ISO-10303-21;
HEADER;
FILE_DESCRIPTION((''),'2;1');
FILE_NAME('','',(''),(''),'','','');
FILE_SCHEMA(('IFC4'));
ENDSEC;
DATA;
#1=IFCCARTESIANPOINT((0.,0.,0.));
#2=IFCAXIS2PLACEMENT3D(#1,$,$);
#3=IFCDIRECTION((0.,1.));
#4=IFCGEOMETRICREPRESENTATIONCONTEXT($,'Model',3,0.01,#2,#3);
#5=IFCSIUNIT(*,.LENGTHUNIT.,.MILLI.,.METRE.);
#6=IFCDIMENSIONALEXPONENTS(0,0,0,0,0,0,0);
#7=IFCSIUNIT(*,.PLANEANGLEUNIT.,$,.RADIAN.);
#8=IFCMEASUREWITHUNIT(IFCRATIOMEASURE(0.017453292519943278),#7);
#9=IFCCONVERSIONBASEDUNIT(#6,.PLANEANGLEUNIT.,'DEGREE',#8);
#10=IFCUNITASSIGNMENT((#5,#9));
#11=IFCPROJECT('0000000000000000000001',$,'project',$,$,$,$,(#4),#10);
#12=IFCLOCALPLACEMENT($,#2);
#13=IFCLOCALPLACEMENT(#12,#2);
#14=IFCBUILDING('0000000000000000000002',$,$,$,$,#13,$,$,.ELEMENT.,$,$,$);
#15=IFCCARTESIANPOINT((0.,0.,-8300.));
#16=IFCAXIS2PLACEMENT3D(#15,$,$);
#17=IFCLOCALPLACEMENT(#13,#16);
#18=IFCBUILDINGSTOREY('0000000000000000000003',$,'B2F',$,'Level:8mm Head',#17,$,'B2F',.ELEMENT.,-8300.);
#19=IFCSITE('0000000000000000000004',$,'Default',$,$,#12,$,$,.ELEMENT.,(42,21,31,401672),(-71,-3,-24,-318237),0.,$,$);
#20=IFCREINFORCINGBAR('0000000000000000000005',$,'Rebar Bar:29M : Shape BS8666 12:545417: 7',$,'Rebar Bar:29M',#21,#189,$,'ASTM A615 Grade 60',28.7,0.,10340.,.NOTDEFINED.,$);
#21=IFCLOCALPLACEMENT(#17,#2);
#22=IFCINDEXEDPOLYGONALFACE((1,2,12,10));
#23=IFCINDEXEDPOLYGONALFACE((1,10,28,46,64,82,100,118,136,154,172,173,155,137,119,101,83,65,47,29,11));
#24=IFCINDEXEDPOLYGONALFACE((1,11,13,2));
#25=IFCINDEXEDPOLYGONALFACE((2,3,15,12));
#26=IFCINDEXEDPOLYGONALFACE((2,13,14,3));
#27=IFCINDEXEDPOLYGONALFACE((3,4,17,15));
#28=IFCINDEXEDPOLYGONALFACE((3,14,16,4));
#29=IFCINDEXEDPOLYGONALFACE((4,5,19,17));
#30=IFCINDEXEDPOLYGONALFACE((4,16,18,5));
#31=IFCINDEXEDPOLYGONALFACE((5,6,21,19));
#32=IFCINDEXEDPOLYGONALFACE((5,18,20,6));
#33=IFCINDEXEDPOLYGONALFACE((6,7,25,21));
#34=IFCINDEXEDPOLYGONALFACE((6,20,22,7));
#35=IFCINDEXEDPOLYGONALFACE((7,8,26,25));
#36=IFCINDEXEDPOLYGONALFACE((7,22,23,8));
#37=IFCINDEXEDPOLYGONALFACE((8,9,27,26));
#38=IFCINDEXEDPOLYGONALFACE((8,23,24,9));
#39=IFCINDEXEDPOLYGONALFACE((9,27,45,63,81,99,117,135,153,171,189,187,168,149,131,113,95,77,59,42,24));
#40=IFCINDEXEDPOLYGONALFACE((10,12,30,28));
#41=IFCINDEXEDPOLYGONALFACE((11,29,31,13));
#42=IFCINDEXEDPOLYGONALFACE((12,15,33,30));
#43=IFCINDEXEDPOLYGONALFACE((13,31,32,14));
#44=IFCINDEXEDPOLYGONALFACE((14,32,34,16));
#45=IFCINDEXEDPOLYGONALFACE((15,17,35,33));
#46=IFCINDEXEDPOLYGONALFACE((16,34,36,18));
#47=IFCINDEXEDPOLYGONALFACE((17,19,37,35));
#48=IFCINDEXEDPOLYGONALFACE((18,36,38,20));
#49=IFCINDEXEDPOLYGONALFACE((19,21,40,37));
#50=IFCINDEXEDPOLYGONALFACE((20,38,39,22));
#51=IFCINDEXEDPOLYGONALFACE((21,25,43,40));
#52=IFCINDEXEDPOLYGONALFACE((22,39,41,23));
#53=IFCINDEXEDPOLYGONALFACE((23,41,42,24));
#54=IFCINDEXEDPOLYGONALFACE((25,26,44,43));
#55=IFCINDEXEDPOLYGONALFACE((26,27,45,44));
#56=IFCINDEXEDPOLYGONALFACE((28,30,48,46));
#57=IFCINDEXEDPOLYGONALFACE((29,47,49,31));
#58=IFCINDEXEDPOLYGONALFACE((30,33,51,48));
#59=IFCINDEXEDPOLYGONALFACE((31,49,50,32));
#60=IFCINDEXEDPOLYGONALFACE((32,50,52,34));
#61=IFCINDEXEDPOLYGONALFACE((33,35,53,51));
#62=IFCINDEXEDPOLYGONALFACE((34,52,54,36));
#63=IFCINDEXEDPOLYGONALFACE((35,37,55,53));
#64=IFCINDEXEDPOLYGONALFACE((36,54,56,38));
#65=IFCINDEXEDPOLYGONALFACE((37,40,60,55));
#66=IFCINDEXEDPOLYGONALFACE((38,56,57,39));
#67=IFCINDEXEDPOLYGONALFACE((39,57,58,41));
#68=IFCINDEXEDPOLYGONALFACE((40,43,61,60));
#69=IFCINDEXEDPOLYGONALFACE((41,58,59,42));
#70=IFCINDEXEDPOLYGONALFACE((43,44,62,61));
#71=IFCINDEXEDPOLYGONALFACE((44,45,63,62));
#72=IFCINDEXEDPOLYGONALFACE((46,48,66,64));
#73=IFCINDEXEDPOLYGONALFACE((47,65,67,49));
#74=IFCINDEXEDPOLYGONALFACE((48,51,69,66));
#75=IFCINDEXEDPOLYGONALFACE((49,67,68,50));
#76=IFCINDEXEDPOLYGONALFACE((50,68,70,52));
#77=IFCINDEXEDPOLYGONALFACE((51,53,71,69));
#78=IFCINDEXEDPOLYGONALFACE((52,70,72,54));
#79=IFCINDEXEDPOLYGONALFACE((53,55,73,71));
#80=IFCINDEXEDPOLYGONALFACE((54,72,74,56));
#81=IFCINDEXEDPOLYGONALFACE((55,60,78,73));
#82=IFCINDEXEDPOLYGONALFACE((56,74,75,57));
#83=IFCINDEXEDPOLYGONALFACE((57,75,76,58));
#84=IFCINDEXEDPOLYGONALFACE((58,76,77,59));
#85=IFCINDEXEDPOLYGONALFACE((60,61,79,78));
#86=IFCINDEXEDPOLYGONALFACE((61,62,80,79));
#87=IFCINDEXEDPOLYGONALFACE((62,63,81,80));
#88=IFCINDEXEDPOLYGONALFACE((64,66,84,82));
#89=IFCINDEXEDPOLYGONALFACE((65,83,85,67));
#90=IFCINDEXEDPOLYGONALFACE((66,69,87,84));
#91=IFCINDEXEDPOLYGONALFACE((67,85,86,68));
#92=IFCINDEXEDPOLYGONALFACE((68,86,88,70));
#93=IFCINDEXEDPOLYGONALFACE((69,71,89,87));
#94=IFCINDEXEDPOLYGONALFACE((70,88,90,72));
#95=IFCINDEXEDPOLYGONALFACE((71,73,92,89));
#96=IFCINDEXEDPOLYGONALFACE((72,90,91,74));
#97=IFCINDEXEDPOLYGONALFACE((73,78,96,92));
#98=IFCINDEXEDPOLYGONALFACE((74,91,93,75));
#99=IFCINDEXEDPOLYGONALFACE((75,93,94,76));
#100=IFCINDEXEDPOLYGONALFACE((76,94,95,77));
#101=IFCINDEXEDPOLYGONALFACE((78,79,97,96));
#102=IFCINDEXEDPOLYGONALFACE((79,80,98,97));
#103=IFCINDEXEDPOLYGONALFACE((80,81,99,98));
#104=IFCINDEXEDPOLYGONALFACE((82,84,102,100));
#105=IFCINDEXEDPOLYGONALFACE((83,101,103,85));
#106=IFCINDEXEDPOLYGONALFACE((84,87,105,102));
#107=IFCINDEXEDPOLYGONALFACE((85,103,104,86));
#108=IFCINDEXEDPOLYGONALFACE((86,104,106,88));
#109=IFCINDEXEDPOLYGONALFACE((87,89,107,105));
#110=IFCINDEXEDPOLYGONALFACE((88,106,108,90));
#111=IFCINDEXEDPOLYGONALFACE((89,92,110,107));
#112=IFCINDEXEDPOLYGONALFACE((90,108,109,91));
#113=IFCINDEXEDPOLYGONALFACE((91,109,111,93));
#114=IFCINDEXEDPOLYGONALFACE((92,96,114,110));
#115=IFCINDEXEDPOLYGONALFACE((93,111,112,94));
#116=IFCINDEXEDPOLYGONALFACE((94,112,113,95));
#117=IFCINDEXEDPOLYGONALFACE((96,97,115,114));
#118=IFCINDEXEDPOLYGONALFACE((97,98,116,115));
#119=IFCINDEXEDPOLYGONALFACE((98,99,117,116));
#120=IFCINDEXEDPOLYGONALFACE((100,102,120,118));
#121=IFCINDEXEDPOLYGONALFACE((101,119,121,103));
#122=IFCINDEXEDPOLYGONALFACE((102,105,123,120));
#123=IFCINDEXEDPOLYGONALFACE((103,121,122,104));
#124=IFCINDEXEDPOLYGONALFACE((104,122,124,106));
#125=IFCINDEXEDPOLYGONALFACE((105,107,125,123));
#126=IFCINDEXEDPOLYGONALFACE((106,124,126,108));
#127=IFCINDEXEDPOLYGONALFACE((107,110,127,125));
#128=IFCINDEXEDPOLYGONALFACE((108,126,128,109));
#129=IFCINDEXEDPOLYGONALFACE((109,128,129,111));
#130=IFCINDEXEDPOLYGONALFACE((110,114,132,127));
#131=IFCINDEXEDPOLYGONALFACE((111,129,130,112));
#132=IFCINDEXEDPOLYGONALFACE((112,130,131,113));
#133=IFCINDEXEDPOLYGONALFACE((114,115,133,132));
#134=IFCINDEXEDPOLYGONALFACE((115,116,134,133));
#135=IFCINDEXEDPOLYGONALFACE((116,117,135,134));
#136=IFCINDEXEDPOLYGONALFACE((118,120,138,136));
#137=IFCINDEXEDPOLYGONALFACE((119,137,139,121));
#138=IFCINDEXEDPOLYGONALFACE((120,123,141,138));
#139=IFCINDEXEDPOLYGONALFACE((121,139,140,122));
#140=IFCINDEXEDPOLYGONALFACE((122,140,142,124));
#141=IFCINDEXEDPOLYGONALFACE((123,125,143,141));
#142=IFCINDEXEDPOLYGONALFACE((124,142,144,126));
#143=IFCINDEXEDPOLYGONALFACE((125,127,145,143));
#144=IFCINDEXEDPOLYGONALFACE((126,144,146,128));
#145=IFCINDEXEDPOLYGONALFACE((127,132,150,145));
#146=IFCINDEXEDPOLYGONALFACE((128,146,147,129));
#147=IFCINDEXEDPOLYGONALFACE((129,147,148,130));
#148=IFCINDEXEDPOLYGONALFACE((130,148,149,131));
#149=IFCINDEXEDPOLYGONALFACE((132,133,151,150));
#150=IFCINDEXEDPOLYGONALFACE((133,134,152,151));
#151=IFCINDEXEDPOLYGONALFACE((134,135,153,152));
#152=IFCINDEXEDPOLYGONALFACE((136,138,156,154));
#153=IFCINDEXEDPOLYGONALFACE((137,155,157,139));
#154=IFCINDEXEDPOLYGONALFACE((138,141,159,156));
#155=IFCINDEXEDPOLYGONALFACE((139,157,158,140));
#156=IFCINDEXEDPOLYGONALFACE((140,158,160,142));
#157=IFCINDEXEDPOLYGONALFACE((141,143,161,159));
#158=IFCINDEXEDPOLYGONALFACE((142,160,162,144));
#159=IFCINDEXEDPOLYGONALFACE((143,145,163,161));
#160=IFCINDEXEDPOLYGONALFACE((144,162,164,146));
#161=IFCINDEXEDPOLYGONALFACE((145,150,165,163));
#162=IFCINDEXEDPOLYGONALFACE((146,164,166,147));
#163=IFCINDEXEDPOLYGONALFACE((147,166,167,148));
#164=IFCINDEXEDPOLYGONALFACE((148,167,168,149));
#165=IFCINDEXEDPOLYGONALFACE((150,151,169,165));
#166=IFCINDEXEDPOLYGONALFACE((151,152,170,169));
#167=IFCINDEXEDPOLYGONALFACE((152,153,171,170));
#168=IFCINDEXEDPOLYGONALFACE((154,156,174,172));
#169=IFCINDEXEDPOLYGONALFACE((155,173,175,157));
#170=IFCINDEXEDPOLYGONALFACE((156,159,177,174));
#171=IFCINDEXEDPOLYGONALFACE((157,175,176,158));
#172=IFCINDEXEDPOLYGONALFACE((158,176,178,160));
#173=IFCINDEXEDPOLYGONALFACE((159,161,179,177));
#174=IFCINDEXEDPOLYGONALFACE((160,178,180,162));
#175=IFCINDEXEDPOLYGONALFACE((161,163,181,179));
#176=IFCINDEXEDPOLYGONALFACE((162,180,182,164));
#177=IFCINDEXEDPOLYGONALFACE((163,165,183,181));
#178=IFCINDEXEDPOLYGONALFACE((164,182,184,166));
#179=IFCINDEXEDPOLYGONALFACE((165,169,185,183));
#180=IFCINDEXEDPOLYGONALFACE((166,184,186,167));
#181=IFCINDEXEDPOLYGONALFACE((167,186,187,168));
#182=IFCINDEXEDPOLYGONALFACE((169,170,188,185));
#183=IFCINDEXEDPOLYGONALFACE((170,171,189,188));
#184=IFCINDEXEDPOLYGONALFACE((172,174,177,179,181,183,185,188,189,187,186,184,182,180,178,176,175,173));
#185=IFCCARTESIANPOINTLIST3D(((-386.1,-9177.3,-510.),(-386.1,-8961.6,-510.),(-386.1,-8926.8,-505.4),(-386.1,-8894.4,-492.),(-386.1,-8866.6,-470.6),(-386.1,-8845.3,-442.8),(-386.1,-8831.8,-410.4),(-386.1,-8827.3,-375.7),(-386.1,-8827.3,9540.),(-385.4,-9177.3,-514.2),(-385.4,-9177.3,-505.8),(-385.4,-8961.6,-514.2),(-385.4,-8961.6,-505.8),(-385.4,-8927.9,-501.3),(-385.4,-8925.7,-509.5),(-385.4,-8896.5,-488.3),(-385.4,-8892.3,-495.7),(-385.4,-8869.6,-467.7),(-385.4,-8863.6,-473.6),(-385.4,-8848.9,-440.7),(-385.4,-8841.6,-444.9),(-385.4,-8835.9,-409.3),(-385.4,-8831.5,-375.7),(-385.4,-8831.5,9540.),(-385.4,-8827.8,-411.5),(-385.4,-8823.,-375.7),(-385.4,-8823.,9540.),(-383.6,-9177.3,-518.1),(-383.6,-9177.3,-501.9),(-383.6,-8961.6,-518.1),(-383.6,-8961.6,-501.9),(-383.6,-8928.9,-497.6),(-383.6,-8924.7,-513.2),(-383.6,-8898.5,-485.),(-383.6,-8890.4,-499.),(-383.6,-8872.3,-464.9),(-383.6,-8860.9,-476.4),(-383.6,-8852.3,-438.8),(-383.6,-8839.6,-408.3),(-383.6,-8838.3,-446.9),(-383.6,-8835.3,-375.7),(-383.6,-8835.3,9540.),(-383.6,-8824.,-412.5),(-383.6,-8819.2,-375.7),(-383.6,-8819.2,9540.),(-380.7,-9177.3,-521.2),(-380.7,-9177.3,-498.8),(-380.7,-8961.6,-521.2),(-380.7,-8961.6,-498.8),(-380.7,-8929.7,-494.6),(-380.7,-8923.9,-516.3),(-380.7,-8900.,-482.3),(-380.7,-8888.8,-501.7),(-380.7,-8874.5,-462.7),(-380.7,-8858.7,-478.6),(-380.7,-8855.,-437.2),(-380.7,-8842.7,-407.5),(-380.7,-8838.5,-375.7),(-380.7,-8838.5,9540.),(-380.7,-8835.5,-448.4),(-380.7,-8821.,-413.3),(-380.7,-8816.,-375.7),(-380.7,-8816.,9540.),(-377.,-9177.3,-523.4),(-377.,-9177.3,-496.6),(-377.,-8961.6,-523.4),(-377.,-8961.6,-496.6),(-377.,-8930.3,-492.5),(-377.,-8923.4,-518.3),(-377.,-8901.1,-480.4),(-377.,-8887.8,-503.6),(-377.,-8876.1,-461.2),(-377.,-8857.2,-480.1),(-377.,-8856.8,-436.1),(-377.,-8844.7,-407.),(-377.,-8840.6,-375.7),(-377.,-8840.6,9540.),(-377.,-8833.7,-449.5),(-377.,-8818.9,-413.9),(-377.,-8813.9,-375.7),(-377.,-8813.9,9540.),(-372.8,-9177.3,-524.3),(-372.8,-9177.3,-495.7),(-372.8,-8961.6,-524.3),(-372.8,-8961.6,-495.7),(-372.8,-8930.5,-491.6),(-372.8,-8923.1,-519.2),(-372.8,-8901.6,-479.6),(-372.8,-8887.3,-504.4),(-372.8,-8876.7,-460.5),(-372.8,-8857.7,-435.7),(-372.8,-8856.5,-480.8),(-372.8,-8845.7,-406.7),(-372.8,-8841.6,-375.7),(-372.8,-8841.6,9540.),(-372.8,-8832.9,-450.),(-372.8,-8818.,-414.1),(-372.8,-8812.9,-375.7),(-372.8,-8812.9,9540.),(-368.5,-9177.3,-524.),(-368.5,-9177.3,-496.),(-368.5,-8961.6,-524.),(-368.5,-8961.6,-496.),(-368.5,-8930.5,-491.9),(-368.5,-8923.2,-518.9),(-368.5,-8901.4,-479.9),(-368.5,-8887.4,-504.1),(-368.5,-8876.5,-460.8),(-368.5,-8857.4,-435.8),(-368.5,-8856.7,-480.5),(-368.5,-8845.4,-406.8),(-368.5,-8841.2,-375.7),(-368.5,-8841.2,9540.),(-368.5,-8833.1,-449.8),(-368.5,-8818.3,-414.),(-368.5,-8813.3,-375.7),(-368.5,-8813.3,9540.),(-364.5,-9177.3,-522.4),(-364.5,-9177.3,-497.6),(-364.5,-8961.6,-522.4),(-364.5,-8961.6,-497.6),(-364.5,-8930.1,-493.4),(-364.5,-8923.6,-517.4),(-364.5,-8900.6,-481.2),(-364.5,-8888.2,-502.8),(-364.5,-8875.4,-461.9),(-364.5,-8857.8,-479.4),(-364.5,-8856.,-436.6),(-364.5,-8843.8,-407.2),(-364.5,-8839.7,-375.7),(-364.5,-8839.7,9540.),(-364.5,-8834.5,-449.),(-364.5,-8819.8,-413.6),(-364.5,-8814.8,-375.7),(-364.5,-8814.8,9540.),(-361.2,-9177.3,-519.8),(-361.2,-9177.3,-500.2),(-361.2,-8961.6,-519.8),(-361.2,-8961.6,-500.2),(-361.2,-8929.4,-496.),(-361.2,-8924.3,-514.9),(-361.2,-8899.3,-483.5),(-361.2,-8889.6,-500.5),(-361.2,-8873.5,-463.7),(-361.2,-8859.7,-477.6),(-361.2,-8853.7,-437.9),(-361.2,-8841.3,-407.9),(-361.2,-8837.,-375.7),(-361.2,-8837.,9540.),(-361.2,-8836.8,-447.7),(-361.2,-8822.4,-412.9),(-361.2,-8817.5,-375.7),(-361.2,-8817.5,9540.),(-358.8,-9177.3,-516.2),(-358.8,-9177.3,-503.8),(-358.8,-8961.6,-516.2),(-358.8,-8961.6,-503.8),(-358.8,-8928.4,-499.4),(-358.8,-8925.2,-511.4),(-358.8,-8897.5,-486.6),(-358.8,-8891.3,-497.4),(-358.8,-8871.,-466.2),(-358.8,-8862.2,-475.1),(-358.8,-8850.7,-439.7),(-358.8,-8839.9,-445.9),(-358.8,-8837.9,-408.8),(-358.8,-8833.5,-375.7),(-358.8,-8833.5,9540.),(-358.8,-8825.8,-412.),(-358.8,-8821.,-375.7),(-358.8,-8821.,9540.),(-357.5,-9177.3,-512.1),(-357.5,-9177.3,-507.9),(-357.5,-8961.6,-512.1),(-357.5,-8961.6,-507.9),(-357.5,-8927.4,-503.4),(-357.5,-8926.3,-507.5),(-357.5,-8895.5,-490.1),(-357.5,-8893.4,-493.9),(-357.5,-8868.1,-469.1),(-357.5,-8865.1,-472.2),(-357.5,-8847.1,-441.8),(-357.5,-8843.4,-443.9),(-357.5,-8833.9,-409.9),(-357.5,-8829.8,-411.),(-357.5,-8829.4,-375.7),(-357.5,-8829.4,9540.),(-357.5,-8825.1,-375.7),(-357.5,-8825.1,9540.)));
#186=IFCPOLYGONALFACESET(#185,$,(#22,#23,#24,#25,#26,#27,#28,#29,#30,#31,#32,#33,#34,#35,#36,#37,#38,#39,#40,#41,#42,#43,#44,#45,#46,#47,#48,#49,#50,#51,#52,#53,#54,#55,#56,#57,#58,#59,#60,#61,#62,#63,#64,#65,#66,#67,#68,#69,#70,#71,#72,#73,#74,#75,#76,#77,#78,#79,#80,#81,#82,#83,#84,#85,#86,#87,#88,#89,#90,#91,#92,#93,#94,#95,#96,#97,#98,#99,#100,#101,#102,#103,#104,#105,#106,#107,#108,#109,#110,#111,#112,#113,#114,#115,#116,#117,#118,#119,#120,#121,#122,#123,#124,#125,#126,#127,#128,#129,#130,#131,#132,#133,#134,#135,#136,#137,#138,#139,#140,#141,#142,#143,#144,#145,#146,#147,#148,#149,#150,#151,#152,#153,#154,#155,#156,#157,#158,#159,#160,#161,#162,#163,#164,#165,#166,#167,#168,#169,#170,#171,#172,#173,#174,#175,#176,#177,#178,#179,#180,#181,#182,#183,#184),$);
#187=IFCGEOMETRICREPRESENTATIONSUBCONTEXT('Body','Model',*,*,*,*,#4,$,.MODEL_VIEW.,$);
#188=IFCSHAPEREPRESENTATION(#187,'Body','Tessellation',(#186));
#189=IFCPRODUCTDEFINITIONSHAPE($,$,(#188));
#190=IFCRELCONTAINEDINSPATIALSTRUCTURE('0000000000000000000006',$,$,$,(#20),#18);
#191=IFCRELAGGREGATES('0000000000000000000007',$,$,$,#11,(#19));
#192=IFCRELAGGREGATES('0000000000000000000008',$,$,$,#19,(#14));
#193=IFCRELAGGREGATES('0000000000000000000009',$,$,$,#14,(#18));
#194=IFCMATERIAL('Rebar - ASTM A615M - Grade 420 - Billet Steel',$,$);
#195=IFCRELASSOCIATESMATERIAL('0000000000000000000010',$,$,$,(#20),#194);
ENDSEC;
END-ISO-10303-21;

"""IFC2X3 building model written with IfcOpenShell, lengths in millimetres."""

from ifc_helpers import new_model, entity, si_unit, converted_unit, direction, frame, origin, place, context, subcontext, project, spatial, material, element, save


model = new_model("IFC2X3")

# Units and contexts
model_context = context("Model", 3, precision=0.01, world=origin(), true_north=direction((0.0, 1.0)))
body_context = subcontext(model_context, "Body", "Model", "MODEL_VIEW")
ifc_project = project(units=[si_unit("LENGTHUNIT", "METRE", prefix="MILLI"), converted_unit("PLANEANGLEUNIT", "DEGREE", entity("IfcRatioMeasure", 0.017453292519943278), si_unit("PLANEANGLEUNIT", "RADIAN"), dimensions=[0, 0, 0, 0, 0, 0, 0])], contexts=[model_context])

# Site, building, storey
site_placement = place(None, origin())
site = spatial("IfcSite", under=ifc_project, at=site_placement, Name="Default", CompositionType="ELEMENT", RefLatitude=(42, 21, 31, 401672), RefLongitude=(-71, -3, -24, -318237), RefElevation=0.0)
building_placement = place(site_placement, origin())
building = spatial("IfcBuilding", under=site, at=building_placement, CompositionType="ELEMENT")
storey_placement = place(building_placement, frame((0.0, 0.0, -8300.0)))
storey = spatial("IfcBuildingStorey", under=building, at=storey_placement, Name="B2F", ObjectType="Level:8mm Head", LongName="B2F", CompositionType="ELEMENT", Elevation=-8300.0)

# Reinforcing bar
ifc_material_1 = material(Name="Rebar - ASTM A615M - Grade 420 - Billet Steel")
reinforcing_bar_1_placement = place(storey_placement, origin())
element("IfcReinforcingBar", 1, at=reinforcing_bar_1_placement, inside=storey, material=ifc_material_1, Name="Rebar Bar:29M : Shape BS8666 12:545417: 7", SteelGrade="ASTM A615 Grade 60", ObjectType="Rebar Bar:29M", BarLength=10340.0, BarRole="NOTDEFINED", CrossSectionArea=0.0, NominalDiameter=28.7, context=body_context, shape_type="AdvancedSweptSolid", body=[
    entity("IfcSweptDiskSolid", entity("IfcCompositeCurve", [entity("IfcCompositeCurveSegment", "CONTINUOUS", True, entity("IfcPolyline", [entity("IfcCartesianPoint", [-371.7, -8827.3, 9540.0]), entity("IfcCartesianPoint", [-371.7, -8827.3, -375.7])])), entity("IfcCompositeCurveSegment", "CONTINUOUS", True, entity("IfcTrimmedCurve", entity("IfcCircle", entity("IfcAxis2Placement3D", entity("IfcCartesianPoint", [-371.7, -8961.6, -375.7]), entity("IfcDirection", [-1.0, 0.0, 0.0]), entity("IfcDirection", [0.0, 0.0, -1.0])), 134.3), [entity("IfcParameterValue", 270.0)], [entity("IfcParameterValue", 360.0)], True, "PARAMETER")), entity("IfcCompositeCurveSegment", "CONTINUOUS", True, entity("IfcPolyline", [entity("IfcCartesianPoint", [-371.7, -8961.6, -510.0]), entity("IfcCartesianPoint", [-371.7, -9177.3, -510.0])]))], False), 14.3, None, 0.0, 92.0),
])

save(model, "model.ifc")
